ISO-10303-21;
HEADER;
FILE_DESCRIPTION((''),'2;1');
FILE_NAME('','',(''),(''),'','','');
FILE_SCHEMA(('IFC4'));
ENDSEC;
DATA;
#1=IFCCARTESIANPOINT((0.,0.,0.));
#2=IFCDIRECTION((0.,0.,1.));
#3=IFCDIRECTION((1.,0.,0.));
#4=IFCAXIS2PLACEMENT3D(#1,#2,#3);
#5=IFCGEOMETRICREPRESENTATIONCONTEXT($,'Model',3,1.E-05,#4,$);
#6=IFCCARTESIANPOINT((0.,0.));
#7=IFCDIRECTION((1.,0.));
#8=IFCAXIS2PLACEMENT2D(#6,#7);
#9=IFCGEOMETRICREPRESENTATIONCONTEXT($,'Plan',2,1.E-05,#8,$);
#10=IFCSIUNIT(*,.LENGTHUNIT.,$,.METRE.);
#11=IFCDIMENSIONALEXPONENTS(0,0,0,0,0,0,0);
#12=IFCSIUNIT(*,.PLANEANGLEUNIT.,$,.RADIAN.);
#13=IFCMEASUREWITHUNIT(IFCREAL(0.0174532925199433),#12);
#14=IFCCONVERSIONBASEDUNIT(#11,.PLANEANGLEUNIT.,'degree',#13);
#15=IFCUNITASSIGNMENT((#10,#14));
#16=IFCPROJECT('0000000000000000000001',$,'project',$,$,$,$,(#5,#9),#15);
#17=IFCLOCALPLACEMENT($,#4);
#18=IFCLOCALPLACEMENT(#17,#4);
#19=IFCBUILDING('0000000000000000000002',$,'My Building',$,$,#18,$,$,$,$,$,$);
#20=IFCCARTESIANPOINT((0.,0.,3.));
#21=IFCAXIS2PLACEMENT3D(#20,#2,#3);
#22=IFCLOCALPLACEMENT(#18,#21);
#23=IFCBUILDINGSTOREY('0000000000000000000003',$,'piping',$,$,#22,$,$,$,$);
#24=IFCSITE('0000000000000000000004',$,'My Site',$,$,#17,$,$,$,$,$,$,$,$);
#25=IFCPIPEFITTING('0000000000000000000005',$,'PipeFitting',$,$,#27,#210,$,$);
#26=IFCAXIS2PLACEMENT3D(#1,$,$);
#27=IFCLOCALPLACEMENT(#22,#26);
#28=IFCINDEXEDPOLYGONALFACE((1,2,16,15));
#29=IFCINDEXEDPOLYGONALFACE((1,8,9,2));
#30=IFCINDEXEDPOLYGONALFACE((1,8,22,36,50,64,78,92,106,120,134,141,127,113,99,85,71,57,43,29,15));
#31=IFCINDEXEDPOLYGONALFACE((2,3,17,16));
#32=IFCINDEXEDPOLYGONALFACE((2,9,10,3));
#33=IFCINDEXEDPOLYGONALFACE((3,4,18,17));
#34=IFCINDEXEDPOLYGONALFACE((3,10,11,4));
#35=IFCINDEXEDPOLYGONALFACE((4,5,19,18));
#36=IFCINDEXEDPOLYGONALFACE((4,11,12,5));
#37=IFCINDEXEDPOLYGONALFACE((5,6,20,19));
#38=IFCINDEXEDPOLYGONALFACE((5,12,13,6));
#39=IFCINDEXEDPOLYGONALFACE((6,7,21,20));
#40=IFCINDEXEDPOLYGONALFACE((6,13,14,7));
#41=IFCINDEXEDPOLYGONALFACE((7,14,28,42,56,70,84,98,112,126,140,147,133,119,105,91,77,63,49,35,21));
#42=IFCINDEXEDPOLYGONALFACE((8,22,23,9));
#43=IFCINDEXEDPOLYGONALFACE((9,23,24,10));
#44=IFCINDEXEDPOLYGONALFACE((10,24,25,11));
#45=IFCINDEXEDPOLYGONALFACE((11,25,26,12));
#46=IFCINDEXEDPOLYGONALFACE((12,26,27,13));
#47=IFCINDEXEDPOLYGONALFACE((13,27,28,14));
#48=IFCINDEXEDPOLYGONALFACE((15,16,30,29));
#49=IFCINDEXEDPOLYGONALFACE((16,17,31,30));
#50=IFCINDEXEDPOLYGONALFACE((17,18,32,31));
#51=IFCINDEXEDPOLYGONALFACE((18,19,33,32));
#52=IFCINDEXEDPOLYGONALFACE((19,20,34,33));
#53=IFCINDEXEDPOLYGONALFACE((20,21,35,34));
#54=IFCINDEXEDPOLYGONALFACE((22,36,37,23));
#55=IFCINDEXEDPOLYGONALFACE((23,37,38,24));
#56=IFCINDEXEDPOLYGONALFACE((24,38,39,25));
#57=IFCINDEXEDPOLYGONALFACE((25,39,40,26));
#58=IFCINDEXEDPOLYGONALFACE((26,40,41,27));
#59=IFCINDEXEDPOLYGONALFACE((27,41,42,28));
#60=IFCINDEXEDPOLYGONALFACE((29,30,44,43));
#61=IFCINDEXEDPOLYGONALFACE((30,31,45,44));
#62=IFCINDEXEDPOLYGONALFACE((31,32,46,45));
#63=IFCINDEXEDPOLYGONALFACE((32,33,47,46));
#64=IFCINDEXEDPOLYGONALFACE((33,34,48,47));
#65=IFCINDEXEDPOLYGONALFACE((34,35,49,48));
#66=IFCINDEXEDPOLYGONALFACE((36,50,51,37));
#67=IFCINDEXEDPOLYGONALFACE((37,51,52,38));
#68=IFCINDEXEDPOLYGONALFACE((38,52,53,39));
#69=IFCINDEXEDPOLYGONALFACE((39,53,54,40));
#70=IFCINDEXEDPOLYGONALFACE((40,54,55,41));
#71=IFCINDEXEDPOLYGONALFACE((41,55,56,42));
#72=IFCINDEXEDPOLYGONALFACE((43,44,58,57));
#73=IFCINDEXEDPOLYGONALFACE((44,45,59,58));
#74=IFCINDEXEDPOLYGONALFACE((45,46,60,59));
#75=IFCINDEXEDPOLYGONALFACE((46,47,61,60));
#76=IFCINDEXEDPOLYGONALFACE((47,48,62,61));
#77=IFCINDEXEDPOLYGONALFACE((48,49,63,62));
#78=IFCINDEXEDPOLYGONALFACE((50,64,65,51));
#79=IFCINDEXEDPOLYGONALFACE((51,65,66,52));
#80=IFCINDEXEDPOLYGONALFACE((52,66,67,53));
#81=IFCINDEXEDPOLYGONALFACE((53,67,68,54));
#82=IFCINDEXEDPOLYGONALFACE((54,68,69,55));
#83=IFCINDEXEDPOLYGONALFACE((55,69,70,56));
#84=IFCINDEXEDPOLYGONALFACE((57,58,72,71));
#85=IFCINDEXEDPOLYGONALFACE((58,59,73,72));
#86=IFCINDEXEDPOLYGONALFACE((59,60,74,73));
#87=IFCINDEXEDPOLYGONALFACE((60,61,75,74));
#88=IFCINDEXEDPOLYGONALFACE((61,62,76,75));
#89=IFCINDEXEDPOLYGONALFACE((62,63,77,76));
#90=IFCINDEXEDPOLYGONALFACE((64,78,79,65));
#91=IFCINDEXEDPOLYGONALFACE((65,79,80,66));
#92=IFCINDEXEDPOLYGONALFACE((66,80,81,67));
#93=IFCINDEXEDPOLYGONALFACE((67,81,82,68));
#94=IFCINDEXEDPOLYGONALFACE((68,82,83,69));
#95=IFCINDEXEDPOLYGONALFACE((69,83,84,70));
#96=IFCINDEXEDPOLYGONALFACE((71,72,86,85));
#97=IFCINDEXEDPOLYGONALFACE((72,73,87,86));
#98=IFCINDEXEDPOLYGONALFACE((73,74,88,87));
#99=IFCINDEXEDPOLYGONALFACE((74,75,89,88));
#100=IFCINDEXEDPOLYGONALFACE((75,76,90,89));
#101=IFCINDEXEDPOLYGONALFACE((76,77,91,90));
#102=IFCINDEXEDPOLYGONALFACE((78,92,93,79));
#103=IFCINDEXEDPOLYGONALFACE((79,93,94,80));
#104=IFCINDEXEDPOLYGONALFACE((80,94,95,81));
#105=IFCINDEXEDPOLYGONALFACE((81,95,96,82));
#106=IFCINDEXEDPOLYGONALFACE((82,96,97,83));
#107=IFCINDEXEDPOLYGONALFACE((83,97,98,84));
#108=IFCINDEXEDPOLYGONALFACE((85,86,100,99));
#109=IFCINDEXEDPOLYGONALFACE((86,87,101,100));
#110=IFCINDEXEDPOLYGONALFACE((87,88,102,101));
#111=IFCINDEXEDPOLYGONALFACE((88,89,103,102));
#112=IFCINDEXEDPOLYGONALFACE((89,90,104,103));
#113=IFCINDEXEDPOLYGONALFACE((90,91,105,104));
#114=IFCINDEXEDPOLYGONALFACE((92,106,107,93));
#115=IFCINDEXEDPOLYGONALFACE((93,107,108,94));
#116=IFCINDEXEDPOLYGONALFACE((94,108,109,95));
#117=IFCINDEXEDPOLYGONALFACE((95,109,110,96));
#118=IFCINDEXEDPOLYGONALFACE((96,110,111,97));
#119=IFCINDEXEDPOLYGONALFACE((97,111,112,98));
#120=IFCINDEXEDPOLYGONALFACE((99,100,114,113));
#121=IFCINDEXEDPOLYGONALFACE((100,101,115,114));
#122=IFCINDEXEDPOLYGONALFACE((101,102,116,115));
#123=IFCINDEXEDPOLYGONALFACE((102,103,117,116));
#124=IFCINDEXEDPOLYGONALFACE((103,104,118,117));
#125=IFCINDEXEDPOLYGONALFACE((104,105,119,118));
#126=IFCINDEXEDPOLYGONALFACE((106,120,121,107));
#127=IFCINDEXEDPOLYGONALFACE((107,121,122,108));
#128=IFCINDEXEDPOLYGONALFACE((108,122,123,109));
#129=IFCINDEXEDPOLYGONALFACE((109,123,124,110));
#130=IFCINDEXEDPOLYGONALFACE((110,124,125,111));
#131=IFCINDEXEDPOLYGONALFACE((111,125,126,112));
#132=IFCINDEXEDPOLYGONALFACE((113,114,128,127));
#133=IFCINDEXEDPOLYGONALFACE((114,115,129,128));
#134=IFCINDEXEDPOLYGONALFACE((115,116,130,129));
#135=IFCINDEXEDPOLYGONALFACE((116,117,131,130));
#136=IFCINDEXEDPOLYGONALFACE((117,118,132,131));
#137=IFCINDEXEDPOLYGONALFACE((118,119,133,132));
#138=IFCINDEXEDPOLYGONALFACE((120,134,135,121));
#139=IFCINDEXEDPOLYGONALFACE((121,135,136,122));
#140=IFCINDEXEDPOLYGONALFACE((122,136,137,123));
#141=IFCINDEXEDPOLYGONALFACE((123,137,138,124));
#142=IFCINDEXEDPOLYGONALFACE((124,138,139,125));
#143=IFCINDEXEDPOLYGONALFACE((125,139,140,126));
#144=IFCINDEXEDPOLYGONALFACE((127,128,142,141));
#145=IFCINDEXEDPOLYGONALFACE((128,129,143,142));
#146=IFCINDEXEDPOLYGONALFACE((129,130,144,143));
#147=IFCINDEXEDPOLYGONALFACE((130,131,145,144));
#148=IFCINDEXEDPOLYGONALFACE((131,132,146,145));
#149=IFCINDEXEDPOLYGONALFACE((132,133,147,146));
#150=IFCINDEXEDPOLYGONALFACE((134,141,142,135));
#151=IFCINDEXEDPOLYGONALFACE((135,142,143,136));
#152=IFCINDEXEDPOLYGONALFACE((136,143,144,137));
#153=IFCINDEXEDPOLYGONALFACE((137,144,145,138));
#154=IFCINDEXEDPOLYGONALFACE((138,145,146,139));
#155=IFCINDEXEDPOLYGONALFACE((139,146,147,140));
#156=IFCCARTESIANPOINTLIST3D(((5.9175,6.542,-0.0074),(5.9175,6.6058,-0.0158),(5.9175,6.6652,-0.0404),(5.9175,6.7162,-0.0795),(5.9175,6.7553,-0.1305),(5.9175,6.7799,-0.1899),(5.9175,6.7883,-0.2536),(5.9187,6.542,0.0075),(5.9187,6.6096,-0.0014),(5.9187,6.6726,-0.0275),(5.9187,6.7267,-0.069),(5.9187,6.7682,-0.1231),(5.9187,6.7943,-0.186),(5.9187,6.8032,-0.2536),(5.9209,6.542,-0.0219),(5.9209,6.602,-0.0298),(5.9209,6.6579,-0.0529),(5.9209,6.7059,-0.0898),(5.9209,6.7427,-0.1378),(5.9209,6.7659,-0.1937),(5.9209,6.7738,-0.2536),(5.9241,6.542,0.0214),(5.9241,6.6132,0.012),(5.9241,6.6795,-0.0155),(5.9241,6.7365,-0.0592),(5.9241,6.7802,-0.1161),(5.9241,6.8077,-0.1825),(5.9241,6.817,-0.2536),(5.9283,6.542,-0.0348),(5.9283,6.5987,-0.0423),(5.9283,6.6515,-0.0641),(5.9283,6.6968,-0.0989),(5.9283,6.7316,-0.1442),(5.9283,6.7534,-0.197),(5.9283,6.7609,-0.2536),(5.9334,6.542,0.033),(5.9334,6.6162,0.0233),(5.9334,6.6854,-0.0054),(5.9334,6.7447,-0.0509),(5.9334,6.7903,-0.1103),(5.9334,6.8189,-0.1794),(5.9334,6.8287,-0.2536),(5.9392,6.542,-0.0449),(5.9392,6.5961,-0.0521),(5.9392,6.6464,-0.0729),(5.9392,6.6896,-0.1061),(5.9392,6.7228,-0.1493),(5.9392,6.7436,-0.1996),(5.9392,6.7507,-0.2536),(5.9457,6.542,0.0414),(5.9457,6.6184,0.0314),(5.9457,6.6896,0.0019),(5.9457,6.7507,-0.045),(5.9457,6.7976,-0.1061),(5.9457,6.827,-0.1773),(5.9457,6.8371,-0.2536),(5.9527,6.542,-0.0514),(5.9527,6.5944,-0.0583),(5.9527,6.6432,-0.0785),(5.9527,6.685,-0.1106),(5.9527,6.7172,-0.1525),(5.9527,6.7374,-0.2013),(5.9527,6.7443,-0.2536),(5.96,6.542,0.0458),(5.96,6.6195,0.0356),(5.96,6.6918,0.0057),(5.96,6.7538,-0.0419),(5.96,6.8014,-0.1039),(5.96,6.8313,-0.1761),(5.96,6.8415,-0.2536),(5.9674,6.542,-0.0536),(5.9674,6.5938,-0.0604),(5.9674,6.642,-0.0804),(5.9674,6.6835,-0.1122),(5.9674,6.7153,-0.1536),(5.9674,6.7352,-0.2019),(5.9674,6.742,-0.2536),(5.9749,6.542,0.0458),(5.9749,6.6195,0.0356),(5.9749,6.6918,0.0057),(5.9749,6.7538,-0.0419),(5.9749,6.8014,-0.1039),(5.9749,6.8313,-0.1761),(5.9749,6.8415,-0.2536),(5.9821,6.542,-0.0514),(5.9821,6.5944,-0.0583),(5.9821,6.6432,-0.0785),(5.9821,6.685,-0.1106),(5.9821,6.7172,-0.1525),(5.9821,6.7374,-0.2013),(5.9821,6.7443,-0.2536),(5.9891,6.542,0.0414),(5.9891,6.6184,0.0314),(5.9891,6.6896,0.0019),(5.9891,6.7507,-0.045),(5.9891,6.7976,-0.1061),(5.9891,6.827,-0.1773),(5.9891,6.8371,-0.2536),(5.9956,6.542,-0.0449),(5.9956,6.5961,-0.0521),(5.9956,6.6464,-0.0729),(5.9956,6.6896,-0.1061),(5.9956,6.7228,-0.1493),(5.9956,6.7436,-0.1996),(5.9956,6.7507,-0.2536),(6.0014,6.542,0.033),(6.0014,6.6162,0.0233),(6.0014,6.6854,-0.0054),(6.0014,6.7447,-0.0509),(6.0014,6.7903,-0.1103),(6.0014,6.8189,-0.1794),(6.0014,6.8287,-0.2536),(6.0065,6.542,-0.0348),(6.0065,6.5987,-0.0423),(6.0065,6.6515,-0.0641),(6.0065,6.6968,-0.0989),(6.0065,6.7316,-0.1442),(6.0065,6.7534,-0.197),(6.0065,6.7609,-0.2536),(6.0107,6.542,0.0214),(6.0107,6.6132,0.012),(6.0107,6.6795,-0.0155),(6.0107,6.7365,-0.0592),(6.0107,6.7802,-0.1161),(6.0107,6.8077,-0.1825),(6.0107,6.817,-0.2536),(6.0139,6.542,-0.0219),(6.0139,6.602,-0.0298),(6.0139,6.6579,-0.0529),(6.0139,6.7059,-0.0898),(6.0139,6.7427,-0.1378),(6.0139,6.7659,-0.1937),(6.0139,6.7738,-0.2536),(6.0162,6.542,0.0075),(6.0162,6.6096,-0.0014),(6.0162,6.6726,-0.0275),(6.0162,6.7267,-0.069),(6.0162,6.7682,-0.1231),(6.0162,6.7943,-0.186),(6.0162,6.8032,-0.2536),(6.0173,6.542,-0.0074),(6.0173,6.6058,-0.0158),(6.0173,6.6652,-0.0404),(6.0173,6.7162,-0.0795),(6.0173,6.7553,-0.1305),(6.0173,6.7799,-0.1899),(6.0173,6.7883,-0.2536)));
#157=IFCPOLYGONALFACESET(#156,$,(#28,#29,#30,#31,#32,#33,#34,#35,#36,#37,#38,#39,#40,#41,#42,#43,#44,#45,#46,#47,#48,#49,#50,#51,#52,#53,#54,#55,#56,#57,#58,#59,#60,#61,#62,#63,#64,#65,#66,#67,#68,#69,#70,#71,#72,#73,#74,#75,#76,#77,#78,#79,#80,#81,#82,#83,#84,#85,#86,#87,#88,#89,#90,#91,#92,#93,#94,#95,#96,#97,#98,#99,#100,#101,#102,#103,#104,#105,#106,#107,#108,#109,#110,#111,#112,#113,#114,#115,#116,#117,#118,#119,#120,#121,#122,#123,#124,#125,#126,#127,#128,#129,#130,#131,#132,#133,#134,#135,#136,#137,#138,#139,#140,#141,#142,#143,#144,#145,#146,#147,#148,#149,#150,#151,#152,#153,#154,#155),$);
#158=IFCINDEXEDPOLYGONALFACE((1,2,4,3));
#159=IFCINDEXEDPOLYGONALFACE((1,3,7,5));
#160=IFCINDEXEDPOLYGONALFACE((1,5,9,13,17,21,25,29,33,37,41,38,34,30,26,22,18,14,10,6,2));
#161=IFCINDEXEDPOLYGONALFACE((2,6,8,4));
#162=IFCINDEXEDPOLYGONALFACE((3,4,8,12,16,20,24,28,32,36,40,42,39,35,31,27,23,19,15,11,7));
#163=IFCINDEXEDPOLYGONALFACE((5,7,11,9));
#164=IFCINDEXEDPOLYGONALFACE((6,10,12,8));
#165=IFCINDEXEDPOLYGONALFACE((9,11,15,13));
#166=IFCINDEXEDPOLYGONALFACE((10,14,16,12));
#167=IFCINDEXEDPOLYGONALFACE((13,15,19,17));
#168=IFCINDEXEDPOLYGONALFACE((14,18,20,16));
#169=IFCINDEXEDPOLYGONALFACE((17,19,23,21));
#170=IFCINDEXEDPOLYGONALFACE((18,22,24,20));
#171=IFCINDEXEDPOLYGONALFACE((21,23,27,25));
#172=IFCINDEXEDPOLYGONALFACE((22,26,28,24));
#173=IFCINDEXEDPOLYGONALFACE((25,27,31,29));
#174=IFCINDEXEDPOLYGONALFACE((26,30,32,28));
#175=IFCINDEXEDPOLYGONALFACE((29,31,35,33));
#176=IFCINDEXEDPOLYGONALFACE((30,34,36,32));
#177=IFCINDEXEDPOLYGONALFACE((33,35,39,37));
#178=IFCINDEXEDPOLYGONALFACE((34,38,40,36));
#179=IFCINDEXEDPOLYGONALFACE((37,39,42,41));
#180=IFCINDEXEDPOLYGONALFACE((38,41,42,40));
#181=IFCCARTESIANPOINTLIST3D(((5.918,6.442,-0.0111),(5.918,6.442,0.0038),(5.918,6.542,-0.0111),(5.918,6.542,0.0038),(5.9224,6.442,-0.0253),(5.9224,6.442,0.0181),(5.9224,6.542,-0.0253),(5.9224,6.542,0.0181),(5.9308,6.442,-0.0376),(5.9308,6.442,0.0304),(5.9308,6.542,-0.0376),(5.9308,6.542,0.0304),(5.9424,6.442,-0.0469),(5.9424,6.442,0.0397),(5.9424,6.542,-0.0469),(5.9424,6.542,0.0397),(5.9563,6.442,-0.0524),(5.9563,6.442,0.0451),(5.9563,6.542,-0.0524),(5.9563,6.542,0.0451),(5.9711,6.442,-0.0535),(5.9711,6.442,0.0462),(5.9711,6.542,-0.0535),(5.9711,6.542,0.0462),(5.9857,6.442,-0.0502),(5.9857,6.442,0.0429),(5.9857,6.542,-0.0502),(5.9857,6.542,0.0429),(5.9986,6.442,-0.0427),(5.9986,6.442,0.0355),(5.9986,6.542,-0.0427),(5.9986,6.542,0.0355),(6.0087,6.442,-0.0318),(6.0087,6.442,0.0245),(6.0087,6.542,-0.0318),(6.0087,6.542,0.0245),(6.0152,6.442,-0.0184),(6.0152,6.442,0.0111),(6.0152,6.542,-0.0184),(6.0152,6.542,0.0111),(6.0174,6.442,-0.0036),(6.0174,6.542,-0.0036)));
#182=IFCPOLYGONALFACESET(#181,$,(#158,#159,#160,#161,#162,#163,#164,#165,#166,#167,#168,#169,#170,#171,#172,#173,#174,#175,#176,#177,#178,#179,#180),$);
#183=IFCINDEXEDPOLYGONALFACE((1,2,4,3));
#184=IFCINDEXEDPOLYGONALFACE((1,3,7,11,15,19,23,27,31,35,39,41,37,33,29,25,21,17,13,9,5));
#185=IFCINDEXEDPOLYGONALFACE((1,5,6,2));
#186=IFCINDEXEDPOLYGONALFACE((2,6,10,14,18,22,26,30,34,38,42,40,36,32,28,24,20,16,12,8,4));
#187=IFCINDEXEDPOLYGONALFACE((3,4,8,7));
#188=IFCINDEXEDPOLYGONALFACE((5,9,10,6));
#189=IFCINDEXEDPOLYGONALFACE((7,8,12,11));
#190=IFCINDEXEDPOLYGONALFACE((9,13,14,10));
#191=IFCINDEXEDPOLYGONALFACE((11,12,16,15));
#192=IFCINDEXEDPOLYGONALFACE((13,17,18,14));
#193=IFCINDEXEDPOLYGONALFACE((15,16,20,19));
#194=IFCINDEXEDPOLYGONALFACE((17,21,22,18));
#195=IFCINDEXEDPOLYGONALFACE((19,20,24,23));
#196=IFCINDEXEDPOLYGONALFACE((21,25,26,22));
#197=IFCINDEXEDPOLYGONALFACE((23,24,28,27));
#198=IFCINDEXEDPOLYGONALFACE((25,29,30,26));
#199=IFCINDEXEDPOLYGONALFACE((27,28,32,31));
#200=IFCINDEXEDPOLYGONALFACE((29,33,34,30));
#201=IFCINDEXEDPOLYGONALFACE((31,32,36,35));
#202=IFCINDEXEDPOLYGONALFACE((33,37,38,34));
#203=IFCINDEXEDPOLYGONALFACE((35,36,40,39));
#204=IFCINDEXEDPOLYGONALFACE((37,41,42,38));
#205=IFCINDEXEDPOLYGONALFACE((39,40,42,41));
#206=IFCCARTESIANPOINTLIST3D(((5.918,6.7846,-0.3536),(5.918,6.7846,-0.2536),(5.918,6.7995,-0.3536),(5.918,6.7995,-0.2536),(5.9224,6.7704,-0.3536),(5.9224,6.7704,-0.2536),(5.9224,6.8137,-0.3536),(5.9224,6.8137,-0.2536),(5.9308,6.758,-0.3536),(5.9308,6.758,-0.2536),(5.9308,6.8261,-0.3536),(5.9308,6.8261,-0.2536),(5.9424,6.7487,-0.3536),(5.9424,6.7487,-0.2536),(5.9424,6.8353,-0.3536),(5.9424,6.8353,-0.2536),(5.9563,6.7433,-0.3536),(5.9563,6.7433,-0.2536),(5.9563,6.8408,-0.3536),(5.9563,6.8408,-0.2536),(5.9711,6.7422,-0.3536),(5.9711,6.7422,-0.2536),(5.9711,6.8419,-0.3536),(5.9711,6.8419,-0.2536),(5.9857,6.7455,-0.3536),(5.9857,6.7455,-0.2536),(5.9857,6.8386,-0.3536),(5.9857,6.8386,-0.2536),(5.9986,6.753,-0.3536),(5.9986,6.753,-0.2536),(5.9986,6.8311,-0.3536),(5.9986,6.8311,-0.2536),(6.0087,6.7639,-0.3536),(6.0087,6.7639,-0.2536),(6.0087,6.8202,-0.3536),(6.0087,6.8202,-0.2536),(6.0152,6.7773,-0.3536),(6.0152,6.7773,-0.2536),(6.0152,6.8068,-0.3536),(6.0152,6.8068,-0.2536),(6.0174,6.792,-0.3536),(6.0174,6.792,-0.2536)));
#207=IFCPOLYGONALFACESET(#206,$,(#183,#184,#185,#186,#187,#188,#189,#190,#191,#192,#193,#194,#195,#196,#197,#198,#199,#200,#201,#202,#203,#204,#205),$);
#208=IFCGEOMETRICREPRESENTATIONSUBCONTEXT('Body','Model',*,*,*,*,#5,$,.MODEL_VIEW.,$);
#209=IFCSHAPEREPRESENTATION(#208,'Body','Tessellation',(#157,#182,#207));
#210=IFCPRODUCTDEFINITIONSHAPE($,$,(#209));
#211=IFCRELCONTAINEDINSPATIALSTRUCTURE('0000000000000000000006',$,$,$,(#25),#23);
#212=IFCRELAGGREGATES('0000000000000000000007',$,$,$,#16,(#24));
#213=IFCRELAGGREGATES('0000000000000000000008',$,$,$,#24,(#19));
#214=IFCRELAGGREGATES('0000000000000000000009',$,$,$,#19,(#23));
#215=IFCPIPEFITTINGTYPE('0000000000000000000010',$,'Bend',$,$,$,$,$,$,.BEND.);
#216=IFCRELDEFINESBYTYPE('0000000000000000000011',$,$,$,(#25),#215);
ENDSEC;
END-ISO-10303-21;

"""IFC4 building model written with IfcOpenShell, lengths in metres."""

from ifc_helpers import new_model, entity, si_unit, converted_unit, frame, origin_with_axes, origin_2d_with_axis, place, context, subcontext, project, spatial, circle, extrude, source, transform, mapped, type_object, type_shapes, element, save


model = new_model("IFC4")

# Units and contexts
model_context = context("Model", 3, precision=1e-05, world=origin_with_axes())
plan_context = context("Plan", 2, precision=1e-05, world=origin_2d_with_axis())
body_context = subcontext(model_context, "Body", "Model", "MODEL_VIEW")
ifc_project = project(units=[si_unit("LENGTHUNIT", "METRE"), converted_unit("PLANEANGLEUNIT", "degree", entity("IfcReal", 0.0174532925199433), si_unit("PLANEANGLEUNIT", "RADIAN"), dimensions=[0, 0, 0, 0, 0, 0, 0])], contexts=[model_context, plan_context])

# Site, building, storey
site_placement = place(None, origin_with_axes())
site = spatial("IfcSite", under=ifc_project, at=site_placement, Name="My Site")
building_placement = place(site_placement, origin_with_axes())
building = spatial("IfcBuilding", under=site, at=building_placement, Name="My Building")
storey_placement = place(building_placement, frame((0.0, 0.0, 3.0), z_axis=(0.0, 0.0, 1.0), x_axis=(1.0, 0.0, 0.0)))
storey = spatial("IfcBuildingStorey", under=building, at=storey_placement, Name="piping")

# Pipe fitting
pipe_fitting_type = type_object("IfcPipeFittingType", Name="Bend", PredefinedType="BEND")
shared_shape = source(origin_with_axes(), body_context, "Body", "SolidModel", [
    entity("IfcSweptDiskSolid", entity("IfcIndexedPolyCurve", entity("IfcCartesianPointList3D", [[0.0, 0.0, -0.1], [0.0, -0.0732, -0.2768], [0.0, -0.25, -0.35]]), [entity("IfcArcIndex", [1, 2, 3])]), 0.05),
    extrude(circle(Radius=0.05), origin_with_axes(), (0.0, 0.0, -1.0), 0.1),
    extrude(circle(Radius=0.05), frame((0.0, -0.25, -0.35), z_axis=(0.0, -1.0, 0.0), x_axis=(1.0, 0.0, 0.0)), (0.0, 0.0, 1.0), 0.1),
])
type_shapes(pipe_fitting_type, [shared_shape])
for number, where, z_axis, x_axis, name in (
    (1, (5.9674, 6.442, -0.0036), (0.0, -1.0, 0.0), (1.0, 0.0, 0.0), "PipeFitting"),
):
    element("IfcPipeFitting", number, at=place(storey_placement, frame(where, z_axis=z_axis, x_axis=x_axis)), inside=storey, type_object=pipe_fitting_type, Name=name, context=body_context, shape_type="MappedRepresentation", body=[
        mapped(shared_shape, transform((0.0, 0.0, 0.0), x_axis=(1.0, 0.0, 0.0), y_axis=(0.0, 1.0, 0.0), z_axis=(0.0, 0.0, 1.0), scale=1.0)),
    ])

save(model, "model.ifc")
